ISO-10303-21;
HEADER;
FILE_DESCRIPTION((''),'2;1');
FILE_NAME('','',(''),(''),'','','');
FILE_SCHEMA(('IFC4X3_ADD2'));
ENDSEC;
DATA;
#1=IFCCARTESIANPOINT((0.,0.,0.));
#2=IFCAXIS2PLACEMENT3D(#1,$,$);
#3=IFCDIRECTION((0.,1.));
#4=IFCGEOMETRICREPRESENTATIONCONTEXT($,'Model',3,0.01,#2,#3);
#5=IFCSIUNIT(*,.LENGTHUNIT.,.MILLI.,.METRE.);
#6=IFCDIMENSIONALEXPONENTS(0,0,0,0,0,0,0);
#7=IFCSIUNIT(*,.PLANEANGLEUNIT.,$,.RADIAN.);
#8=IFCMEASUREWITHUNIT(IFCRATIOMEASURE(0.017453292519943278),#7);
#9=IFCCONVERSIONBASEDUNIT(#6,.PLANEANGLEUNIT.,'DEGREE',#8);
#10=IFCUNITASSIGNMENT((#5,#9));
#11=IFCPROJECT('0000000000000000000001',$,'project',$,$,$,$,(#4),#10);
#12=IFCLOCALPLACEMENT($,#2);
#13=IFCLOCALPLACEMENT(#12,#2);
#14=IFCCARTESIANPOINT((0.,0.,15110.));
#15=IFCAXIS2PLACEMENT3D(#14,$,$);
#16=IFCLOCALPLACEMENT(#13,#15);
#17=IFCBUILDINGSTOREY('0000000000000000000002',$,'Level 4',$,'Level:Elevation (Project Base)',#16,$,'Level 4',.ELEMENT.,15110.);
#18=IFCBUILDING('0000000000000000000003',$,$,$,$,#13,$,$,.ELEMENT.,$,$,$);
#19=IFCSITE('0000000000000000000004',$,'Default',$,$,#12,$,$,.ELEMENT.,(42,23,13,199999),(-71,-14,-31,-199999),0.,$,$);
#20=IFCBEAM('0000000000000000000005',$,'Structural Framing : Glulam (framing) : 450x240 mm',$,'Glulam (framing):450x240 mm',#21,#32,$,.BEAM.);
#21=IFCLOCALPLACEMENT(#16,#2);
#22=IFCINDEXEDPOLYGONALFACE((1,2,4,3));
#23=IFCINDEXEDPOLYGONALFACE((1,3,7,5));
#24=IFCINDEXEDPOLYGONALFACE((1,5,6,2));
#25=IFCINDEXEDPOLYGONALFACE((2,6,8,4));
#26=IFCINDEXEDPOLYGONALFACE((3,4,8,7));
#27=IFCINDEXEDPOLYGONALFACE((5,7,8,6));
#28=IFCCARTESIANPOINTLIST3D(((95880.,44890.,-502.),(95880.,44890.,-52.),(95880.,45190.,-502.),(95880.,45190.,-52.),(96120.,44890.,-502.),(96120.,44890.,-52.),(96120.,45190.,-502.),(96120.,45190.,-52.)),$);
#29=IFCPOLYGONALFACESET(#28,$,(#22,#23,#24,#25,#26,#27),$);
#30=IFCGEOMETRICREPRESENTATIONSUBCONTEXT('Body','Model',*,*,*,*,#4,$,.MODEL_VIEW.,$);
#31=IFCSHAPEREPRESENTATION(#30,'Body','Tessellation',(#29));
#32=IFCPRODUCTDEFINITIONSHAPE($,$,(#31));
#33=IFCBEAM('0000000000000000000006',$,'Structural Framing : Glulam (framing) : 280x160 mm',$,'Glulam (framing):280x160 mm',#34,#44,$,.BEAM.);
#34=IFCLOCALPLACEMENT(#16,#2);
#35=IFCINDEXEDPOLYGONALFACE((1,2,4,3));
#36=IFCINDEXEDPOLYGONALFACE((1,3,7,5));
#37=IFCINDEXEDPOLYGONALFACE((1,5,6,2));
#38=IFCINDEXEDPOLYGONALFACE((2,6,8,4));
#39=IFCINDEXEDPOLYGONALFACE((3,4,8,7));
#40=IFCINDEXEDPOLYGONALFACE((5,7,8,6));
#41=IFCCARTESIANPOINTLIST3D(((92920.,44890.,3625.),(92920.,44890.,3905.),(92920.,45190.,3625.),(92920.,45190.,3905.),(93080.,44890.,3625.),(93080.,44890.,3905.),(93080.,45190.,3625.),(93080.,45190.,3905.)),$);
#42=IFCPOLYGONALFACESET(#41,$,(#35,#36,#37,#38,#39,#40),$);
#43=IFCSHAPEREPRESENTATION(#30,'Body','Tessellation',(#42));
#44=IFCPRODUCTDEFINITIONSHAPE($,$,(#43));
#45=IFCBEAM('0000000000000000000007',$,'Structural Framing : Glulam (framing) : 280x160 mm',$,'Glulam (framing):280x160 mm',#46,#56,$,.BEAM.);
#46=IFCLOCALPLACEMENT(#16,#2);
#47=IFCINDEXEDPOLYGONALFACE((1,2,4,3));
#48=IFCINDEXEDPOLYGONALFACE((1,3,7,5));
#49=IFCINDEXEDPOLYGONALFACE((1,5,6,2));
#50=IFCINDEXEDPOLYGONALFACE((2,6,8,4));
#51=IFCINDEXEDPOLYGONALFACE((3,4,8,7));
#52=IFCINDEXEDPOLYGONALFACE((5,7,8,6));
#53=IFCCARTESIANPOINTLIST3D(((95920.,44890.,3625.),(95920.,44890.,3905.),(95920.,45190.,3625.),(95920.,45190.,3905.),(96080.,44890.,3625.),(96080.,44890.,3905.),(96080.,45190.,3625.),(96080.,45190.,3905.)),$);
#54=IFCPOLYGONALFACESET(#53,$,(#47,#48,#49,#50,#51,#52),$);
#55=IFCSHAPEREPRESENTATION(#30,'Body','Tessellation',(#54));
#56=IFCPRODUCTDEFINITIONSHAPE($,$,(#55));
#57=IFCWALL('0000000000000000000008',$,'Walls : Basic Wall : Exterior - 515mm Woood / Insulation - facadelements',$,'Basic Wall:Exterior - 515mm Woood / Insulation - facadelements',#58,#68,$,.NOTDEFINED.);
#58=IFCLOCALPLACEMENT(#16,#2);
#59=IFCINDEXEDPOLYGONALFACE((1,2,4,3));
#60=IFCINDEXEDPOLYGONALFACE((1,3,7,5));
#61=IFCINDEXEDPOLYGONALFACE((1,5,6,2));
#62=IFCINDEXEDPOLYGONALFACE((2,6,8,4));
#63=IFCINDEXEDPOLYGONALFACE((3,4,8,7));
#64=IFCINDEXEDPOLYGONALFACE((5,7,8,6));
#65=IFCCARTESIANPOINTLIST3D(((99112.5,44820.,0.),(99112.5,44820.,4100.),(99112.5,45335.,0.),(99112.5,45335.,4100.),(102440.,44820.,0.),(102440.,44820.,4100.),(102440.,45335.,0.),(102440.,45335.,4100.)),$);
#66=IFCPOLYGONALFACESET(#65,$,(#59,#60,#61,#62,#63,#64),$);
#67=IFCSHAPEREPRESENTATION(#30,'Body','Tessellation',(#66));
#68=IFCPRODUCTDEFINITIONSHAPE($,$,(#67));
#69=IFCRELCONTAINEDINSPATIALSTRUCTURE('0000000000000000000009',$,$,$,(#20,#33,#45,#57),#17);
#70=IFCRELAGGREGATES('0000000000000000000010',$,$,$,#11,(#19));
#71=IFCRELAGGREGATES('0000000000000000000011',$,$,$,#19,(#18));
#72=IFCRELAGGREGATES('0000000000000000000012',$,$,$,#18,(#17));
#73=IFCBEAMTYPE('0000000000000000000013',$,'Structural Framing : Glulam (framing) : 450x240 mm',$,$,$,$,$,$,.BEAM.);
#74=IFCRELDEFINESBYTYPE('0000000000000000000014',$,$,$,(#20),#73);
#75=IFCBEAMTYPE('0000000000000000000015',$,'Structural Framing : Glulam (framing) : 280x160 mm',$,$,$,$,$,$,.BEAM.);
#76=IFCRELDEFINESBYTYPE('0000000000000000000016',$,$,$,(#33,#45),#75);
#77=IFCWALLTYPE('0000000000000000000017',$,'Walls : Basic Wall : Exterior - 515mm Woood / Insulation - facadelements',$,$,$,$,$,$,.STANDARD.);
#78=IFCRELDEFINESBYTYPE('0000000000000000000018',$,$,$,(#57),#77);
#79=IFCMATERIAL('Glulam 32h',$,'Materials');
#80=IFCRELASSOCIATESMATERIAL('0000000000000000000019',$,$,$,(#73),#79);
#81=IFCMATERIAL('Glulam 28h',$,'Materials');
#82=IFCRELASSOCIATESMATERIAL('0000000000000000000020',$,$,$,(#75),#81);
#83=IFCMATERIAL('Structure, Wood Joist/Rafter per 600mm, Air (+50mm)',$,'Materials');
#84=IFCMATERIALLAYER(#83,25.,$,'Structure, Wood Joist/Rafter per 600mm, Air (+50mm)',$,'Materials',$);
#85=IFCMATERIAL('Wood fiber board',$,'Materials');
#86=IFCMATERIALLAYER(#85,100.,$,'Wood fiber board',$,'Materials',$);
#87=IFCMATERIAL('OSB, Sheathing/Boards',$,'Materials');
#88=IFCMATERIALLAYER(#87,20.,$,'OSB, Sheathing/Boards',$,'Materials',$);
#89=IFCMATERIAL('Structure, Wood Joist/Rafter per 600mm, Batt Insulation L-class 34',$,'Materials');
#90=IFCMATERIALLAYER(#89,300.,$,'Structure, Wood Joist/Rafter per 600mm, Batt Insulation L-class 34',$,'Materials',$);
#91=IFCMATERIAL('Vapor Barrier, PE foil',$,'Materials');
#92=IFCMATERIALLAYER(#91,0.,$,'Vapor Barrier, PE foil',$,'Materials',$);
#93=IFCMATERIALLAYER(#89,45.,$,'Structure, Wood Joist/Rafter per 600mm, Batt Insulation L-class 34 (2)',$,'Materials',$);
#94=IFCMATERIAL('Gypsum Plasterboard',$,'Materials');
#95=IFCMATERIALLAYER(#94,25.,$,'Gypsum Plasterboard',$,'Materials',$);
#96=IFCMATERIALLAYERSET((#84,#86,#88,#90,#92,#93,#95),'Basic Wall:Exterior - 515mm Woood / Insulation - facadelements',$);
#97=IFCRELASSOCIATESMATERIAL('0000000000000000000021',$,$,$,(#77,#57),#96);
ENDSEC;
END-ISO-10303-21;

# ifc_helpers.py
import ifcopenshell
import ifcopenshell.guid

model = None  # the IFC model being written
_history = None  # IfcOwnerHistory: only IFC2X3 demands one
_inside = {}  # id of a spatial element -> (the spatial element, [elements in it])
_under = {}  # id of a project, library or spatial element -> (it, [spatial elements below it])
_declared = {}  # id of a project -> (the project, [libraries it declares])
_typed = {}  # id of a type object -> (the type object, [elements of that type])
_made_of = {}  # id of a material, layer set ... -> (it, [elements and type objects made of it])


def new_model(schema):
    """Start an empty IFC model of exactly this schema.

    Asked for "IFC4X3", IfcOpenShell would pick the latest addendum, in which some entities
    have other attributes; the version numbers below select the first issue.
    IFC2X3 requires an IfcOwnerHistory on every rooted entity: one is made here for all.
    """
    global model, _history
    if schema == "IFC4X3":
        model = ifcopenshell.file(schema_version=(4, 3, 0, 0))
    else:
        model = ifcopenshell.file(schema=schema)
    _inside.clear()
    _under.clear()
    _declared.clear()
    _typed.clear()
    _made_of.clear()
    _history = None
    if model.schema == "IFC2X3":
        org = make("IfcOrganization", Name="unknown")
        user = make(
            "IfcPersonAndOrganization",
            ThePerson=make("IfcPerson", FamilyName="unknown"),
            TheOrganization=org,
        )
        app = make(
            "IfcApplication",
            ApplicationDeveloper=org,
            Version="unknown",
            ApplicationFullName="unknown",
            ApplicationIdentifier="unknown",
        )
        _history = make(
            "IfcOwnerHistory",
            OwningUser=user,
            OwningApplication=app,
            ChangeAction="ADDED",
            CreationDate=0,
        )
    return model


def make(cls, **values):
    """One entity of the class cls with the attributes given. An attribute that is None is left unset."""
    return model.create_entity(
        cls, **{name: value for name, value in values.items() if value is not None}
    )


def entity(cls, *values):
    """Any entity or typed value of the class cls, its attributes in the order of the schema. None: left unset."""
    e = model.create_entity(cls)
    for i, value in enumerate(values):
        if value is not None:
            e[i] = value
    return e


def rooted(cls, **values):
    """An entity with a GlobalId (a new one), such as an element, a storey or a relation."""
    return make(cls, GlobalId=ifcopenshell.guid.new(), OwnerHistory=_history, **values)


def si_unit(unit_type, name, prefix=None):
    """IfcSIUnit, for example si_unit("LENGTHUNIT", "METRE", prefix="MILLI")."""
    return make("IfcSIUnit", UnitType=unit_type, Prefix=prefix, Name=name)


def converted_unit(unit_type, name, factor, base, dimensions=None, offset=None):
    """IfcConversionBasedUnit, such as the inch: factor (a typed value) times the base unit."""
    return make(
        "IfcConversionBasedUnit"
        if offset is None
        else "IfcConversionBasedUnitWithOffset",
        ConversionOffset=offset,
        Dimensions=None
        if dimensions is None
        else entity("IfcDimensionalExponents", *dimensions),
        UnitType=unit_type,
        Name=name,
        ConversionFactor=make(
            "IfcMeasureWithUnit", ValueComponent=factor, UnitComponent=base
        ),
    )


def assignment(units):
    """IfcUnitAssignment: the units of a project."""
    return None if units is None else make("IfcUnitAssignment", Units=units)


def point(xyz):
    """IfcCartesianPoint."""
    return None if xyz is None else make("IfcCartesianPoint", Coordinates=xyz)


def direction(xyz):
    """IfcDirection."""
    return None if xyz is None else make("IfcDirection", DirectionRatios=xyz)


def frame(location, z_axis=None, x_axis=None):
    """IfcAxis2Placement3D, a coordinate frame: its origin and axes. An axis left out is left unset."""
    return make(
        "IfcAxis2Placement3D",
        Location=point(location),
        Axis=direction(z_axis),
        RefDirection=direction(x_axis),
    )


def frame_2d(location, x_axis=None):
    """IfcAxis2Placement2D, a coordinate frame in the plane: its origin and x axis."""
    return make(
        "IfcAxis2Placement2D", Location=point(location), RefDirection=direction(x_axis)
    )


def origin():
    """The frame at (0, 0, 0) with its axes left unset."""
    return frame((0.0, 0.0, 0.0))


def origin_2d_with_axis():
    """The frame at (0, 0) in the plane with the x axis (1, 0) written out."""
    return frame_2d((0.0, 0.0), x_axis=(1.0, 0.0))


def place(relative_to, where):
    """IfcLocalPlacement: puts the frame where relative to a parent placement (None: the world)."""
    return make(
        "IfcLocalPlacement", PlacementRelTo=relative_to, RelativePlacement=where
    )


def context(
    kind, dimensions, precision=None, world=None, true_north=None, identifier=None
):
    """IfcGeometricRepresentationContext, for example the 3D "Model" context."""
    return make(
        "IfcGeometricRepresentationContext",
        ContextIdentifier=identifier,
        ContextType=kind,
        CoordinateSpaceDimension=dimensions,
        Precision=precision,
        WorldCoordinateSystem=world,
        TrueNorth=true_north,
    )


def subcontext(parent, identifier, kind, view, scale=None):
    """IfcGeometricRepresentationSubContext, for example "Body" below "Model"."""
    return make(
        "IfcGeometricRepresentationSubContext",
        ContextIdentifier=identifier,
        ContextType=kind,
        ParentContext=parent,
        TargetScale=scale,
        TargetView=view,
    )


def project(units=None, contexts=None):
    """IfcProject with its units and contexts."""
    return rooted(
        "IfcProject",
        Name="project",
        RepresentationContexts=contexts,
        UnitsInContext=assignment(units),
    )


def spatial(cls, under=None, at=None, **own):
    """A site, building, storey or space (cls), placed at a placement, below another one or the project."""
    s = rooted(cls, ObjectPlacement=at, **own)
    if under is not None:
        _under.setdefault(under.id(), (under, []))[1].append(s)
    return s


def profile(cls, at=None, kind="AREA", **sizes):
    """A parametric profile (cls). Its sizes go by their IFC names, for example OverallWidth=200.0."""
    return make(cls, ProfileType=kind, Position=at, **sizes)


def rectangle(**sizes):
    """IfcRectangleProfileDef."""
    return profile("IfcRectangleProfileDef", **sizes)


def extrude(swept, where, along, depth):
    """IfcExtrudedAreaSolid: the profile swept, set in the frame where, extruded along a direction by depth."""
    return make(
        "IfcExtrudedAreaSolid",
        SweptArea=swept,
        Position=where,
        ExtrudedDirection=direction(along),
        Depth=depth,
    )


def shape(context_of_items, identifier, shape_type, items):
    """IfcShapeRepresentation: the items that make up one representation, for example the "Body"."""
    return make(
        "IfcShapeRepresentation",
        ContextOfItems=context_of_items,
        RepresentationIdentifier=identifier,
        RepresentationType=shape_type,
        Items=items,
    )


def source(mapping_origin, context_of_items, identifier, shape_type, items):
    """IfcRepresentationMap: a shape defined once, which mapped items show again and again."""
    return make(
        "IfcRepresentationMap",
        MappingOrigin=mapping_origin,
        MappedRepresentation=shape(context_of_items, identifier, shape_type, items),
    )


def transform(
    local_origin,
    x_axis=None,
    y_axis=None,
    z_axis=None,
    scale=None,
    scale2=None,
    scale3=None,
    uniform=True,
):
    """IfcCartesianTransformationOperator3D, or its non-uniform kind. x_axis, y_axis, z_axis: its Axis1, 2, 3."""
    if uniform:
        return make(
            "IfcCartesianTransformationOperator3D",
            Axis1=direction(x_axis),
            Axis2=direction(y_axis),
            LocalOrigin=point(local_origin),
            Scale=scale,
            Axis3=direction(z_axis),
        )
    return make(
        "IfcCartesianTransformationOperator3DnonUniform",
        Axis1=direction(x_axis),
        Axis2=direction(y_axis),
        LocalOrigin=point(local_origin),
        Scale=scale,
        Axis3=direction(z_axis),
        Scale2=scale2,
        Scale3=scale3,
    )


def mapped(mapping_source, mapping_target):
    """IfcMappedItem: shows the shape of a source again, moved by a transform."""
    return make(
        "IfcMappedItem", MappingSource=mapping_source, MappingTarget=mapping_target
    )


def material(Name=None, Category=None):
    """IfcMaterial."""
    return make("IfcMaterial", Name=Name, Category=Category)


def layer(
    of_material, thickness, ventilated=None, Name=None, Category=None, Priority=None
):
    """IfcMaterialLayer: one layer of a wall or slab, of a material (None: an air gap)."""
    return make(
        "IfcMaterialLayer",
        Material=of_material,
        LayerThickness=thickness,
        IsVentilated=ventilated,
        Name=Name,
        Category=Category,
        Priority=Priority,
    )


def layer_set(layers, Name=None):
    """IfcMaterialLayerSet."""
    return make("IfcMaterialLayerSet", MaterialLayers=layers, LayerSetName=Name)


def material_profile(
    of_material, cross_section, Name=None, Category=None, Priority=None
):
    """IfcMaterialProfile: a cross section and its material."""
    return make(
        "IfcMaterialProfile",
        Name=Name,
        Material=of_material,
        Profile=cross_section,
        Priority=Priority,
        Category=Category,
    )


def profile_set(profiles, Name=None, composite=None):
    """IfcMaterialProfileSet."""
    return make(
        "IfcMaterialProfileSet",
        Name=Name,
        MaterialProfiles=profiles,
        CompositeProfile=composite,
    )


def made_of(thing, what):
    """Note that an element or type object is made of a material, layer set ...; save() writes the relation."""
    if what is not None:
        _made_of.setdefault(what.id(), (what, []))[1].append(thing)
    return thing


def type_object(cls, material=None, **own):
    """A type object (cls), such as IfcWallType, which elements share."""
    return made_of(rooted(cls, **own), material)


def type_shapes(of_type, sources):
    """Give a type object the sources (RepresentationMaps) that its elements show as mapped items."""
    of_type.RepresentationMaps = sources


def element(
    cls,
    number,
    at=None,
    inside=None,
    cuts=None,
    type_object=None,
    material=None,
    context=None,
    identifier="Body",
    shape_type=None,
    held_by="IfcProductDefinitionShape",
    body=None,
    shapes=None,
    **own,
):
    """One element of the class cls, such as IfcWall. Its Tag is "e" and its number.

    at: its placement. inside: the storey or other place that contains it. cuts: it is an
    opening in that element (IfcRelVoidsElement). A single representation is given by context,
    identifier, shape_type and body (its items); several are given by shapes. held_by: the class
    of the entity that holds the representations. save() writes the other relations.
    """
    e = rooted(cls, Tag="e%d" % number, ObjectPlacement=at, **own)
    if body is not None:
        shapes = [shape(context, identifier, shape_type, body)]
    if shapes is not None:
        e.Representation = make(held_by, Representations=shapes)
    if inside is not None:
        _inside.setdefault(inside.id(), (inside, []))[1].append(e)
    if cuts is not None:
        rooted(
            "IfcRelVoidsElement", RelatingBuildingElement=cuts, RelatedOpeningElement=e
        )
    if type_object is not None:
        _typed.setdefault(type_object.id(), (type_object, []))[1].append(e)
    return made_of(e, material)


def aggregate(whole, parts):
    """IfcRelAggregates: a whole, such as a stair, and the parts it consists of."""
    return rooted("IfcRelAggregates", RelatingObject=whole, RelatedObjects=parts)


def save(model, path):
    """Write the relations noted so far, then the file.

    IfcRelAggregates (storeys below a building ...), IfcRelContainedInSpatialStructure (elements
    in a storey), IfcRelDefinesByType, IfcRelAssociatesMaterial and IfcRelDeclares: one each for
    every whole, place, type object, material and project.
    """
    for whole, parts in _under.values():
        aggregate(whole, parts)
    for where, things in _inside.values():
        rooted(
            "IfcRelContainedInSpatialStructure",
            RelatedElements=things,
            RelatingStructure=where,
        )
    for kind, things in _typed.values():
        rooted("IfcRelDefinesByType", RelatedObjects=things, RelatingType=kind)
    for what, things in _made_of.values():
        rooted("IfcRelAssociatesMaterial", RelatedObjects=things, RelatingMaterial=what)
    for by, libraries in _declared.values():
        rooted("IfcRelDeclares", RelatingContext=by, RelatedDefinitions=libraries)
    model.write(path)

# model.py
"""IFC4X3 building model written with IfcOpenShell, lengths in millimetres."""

from ifc_helpers import new_model, entity, si_unit, converted_unit, direction, frame, frame_2d, origin, origin_2d_with_axis, place, context, subcontext, project, spatial, rectangle, extrude, source, transform, mapped, material, layer, layer_set, material_profile, profile_set, type_object, type_shapes, element, save


model = new_model("IFC4X3")

# Units and contexts
model_context = context("Model", 3, precision=0.01, world=origin(), true_north=direction((0.0, 1.0)))
body_context = subcontext(model_context, "Body", "Model", "MODEL_VIEW")
ifc_project = project(units=[si_unit("LENGTHUNIT", "METRE", prefix="MILLI"), converted_unit("PLANEANGLEUNIT", "DEGREE", entity("IfcRatioMeasure", 0.017453292519943278), si_unit("PLANEANGLEUNIT", "RADIAN"), dimensions=[0, 0, 0, 0, 0, 0, 0])], contexts=[model_context])

# Site, building, storey
site_placement = place(None, origin())
site = spatial("IfcSite", under=ifc_project, at=site_placement, Name="Default", CompositionType="ELEMENT", RefLatitude=(42, 23, 13, 199999), RefLongitude=(-71, -14, -31, -199999), RefElevation=0.0)
building_placement = place(site_placement, origin())
building = spatial("IfcBuilding", under=site, at=building_placement, CompositionType="ELEMENT")
storey_placement = place(building_placement, frame((0.0, 0.0, 15110.0)))
storey = spatial("IfcBuildingStorey", under=building, at=storey_placement, Name="Level 4", ObjectType="Level:Elevation (Project Base)", LongName="Level 4", CompositionType="ELEMENT", Elevation=15110.0)

# Beams
ifc_material_1 = material(Name="Glulam 32h", Category="Materials")
ifc_material_profile_1 = material_profile(ifc_material_1, rectangle(XDim=450.0, YDim=240.0, at=origin_2d_with_axis()), Name="450x240 mm")
ifc_profile_set_1 = profile_set([ifc_material_profile_1], Name="450x240 mm")
beam_type_1 = type_object("IfcBeamType", Name="Structural Framing : Glulam (framing) : 450x240 mm", PredefinedType="BEAM", material=ifc_profile_set_1)
shared_shape_1 = source(origin(), body_context, "Body", "SweptSolid", [
    extrude(rectangle(XDim=450.0, YDim=240.0, at=origin_2d_with_axis()), frame((-1110.0, 0.0, 0.0), z_axis=(1.0, 0.0, 0.0), x_axis=(0.0, 0.0, -1.0)), (0.0, 0.0, 1.0), 300.0),
])
type_shapes(beam_type_1, [shared_shape_1])
for number, where, z_axis, x_axis, name in (
    (1, (96000.0, 44080.0, -277.0), (0.0, 0.0, 1.0), (0.0, -1.0, 0.0), "Structural Framing : Glulam (framing) : 450x240 mm"),
):
    element("IfcBeam", number, at=place(storey_placement, frame(where, z_axis=z_axis, x_axis=x_axis)), inside=storey, type_object=beam_type_1, Name=name, ObjectType="Glulam (framing):450x240 mm", PredefinedType="BEAM", context=body_context, shape_type="MappedRepresentation", body=[
        mapped(shared_shape_1, transform((0.0, 0.0, 0.0), scale=1.0)),
    ])
ifc_material_2 = material(Name="Glulam 28h", Category="Materials")
ifc_material_profile_2 = material_profile(ifc_material_2, rectangle(XDim=280.0, YDim=160.0, at=origin_2d_with_axis()), Name="280x160 mm")
ifc_profile_set_2 = profile_set([ifc_material_profile_2], Name="280x160 mm")
beam_type_2 = type_object("IfcBeamType", Name="Structural Framing : Glulam (framing) : 280x160 mm", PredefinedType="BEAM", material=ifc_profile_set_2)
shared_shape_2 = source(origin(), body_context, "Body", "SweptSolid", [
    extrude(rectangle(XDim=280.0, YDim=160.0, at=origin_2d_with_axis()), frame((5322.5, 0.0, 0.0), z_axis=(1.0, 0.0, 0.0), x_axis=(0.0, 0.0, -1.0)), (0.0, 0.0, 1.0), 300.0),
])
type_shapes(beam_type_2, [shared_shape_2])
for number, where, z_axis, x_axis, name in (
    (2, (93000.0, 50512.5, 3765.0), (0.0, 0.0, 1.0), (0.0, -1.0, 0.0), "Structural Framing : Glulam (framing) : 280x160 mm"),
    (3, (96000.0, 50512.5, 3765.0), (0.0, 0.0, 1.0), (0.0, -1.0, 0.0), "Structural Framing : Glulam (framing) : 280x160 mm"),
):
    element("IfcBeam", number, at=place(storey_placement, frame(where, z_axis=z_axis, x_axis=x_axis)), inside=storey, type_object=beam_type_2, Name=name, ObjectType="Glulam (framing):280x160 mm", PredefinedType="BEAM", context=body_context, shape_type="MappedRepresentation", body=[
        mapped(shared_shape_2, transform((0.0, 0.0, 0.0), scale=1.0)),
    ])

# Wall
ifc_material_3 = material(Name="Structure, Wood Joist/Rafter per 600mm, Air (+50mm)", Category="Materials")
ifc_layer_1 = layer(ifc_material_3, 25.0, Name="Structure, Wood Joist/Rafter per 600mm, Air (+50mm)", Category="Materials")
ifc_material_4 = material(Name="Wood fiber board", Category="Materials")
ifc_layer_2 = layer(ifc_material_4, 100.0, Name="Wood fiber board", Category="Materials")
ifc_material_5 = material(Name="OSB, Sheathing/Boards", Category="Materials")
ifc_layer_3 = layer(ifc_material_5, 20.0, Name="OSB, Sheathing/Boards", Category="Materials")
ifc_material_6 = material(Name="Structure, Wood Joist/Rafter per 600mm, Batt Insulation L-class 34", Category="Materials")
ifc_layer_4 = layer(ifc_material_6, 300.0, Name="Structure, Wood Joist/Rafter per 600mm, Batt Insulation L-class 34", Category="Materials")
ifc_material_7 = material(Name="Vapor Barrier, PE foil", Category="Materials")
ifc_layer_5 = layer(ifc_material_7, 0.0, Name="Vapor Barrier, PE foil", Category="Materials")
ifc_layer_6 = layer(ifc_material_6, 45.0, Name="Structure, Wood Joist/Rafter per 600mm, Batt Insulation L-class 34 (2)", Category="Materials")
ifc_material_8 = material(Name="Gypsum Plasterboard", Category="Materials")
ifc_layer_7 = layer(ifc_material_8, 25.0, Name="Gypsum Plasterboard", Category="Materials")
ifc_layer_set = layer_set([ifc_layer_1, ifc_layer_2, ifc_layer_3, ifc_layer_4, ifc_layer_5, ifc_layer_6, ifc_layer_7], Name="Basic Wall:Exterior - 515mm Woood / Insulation - facadelements")
wall_type = type_object("IfcWallType", Name="Walls : Basic Wall : Exterior - 515mm Woood / Insulation - facadelements", PredefinedType="STANDARD", material=ifc_layer_set)
wall_placement = place(storey_placement, frame((102440.0, 45077.5, 0.0), z_axis=(0.0, 0.0, 1.0), x_axis=(-1.0, 0.0, 0.0)))
element("IfcWall", 4, at=wall_placement, inside=storey, type_object=wall_type, material=ifc_layer_set, Name="Walls : Basic Wall : Exterior - 515mm Woood / Insulation - facadelements", ObjectType="Basic Wall:Exterior - 515mm Woood / Insulation - facadelements", PredefinedType="NOTDEFINED", context=body_context, shape_type="SweptSolid", body=[
    extrude(rectangle(XDim=3327.5, YDim=515.0, at=frame_2d((1663.7, 0.0), x_axis=(-1.0, 0.0))), origin(), (0.0, 0.0, 1.0), 4100.0),
])

save(model, "model.ifc")
